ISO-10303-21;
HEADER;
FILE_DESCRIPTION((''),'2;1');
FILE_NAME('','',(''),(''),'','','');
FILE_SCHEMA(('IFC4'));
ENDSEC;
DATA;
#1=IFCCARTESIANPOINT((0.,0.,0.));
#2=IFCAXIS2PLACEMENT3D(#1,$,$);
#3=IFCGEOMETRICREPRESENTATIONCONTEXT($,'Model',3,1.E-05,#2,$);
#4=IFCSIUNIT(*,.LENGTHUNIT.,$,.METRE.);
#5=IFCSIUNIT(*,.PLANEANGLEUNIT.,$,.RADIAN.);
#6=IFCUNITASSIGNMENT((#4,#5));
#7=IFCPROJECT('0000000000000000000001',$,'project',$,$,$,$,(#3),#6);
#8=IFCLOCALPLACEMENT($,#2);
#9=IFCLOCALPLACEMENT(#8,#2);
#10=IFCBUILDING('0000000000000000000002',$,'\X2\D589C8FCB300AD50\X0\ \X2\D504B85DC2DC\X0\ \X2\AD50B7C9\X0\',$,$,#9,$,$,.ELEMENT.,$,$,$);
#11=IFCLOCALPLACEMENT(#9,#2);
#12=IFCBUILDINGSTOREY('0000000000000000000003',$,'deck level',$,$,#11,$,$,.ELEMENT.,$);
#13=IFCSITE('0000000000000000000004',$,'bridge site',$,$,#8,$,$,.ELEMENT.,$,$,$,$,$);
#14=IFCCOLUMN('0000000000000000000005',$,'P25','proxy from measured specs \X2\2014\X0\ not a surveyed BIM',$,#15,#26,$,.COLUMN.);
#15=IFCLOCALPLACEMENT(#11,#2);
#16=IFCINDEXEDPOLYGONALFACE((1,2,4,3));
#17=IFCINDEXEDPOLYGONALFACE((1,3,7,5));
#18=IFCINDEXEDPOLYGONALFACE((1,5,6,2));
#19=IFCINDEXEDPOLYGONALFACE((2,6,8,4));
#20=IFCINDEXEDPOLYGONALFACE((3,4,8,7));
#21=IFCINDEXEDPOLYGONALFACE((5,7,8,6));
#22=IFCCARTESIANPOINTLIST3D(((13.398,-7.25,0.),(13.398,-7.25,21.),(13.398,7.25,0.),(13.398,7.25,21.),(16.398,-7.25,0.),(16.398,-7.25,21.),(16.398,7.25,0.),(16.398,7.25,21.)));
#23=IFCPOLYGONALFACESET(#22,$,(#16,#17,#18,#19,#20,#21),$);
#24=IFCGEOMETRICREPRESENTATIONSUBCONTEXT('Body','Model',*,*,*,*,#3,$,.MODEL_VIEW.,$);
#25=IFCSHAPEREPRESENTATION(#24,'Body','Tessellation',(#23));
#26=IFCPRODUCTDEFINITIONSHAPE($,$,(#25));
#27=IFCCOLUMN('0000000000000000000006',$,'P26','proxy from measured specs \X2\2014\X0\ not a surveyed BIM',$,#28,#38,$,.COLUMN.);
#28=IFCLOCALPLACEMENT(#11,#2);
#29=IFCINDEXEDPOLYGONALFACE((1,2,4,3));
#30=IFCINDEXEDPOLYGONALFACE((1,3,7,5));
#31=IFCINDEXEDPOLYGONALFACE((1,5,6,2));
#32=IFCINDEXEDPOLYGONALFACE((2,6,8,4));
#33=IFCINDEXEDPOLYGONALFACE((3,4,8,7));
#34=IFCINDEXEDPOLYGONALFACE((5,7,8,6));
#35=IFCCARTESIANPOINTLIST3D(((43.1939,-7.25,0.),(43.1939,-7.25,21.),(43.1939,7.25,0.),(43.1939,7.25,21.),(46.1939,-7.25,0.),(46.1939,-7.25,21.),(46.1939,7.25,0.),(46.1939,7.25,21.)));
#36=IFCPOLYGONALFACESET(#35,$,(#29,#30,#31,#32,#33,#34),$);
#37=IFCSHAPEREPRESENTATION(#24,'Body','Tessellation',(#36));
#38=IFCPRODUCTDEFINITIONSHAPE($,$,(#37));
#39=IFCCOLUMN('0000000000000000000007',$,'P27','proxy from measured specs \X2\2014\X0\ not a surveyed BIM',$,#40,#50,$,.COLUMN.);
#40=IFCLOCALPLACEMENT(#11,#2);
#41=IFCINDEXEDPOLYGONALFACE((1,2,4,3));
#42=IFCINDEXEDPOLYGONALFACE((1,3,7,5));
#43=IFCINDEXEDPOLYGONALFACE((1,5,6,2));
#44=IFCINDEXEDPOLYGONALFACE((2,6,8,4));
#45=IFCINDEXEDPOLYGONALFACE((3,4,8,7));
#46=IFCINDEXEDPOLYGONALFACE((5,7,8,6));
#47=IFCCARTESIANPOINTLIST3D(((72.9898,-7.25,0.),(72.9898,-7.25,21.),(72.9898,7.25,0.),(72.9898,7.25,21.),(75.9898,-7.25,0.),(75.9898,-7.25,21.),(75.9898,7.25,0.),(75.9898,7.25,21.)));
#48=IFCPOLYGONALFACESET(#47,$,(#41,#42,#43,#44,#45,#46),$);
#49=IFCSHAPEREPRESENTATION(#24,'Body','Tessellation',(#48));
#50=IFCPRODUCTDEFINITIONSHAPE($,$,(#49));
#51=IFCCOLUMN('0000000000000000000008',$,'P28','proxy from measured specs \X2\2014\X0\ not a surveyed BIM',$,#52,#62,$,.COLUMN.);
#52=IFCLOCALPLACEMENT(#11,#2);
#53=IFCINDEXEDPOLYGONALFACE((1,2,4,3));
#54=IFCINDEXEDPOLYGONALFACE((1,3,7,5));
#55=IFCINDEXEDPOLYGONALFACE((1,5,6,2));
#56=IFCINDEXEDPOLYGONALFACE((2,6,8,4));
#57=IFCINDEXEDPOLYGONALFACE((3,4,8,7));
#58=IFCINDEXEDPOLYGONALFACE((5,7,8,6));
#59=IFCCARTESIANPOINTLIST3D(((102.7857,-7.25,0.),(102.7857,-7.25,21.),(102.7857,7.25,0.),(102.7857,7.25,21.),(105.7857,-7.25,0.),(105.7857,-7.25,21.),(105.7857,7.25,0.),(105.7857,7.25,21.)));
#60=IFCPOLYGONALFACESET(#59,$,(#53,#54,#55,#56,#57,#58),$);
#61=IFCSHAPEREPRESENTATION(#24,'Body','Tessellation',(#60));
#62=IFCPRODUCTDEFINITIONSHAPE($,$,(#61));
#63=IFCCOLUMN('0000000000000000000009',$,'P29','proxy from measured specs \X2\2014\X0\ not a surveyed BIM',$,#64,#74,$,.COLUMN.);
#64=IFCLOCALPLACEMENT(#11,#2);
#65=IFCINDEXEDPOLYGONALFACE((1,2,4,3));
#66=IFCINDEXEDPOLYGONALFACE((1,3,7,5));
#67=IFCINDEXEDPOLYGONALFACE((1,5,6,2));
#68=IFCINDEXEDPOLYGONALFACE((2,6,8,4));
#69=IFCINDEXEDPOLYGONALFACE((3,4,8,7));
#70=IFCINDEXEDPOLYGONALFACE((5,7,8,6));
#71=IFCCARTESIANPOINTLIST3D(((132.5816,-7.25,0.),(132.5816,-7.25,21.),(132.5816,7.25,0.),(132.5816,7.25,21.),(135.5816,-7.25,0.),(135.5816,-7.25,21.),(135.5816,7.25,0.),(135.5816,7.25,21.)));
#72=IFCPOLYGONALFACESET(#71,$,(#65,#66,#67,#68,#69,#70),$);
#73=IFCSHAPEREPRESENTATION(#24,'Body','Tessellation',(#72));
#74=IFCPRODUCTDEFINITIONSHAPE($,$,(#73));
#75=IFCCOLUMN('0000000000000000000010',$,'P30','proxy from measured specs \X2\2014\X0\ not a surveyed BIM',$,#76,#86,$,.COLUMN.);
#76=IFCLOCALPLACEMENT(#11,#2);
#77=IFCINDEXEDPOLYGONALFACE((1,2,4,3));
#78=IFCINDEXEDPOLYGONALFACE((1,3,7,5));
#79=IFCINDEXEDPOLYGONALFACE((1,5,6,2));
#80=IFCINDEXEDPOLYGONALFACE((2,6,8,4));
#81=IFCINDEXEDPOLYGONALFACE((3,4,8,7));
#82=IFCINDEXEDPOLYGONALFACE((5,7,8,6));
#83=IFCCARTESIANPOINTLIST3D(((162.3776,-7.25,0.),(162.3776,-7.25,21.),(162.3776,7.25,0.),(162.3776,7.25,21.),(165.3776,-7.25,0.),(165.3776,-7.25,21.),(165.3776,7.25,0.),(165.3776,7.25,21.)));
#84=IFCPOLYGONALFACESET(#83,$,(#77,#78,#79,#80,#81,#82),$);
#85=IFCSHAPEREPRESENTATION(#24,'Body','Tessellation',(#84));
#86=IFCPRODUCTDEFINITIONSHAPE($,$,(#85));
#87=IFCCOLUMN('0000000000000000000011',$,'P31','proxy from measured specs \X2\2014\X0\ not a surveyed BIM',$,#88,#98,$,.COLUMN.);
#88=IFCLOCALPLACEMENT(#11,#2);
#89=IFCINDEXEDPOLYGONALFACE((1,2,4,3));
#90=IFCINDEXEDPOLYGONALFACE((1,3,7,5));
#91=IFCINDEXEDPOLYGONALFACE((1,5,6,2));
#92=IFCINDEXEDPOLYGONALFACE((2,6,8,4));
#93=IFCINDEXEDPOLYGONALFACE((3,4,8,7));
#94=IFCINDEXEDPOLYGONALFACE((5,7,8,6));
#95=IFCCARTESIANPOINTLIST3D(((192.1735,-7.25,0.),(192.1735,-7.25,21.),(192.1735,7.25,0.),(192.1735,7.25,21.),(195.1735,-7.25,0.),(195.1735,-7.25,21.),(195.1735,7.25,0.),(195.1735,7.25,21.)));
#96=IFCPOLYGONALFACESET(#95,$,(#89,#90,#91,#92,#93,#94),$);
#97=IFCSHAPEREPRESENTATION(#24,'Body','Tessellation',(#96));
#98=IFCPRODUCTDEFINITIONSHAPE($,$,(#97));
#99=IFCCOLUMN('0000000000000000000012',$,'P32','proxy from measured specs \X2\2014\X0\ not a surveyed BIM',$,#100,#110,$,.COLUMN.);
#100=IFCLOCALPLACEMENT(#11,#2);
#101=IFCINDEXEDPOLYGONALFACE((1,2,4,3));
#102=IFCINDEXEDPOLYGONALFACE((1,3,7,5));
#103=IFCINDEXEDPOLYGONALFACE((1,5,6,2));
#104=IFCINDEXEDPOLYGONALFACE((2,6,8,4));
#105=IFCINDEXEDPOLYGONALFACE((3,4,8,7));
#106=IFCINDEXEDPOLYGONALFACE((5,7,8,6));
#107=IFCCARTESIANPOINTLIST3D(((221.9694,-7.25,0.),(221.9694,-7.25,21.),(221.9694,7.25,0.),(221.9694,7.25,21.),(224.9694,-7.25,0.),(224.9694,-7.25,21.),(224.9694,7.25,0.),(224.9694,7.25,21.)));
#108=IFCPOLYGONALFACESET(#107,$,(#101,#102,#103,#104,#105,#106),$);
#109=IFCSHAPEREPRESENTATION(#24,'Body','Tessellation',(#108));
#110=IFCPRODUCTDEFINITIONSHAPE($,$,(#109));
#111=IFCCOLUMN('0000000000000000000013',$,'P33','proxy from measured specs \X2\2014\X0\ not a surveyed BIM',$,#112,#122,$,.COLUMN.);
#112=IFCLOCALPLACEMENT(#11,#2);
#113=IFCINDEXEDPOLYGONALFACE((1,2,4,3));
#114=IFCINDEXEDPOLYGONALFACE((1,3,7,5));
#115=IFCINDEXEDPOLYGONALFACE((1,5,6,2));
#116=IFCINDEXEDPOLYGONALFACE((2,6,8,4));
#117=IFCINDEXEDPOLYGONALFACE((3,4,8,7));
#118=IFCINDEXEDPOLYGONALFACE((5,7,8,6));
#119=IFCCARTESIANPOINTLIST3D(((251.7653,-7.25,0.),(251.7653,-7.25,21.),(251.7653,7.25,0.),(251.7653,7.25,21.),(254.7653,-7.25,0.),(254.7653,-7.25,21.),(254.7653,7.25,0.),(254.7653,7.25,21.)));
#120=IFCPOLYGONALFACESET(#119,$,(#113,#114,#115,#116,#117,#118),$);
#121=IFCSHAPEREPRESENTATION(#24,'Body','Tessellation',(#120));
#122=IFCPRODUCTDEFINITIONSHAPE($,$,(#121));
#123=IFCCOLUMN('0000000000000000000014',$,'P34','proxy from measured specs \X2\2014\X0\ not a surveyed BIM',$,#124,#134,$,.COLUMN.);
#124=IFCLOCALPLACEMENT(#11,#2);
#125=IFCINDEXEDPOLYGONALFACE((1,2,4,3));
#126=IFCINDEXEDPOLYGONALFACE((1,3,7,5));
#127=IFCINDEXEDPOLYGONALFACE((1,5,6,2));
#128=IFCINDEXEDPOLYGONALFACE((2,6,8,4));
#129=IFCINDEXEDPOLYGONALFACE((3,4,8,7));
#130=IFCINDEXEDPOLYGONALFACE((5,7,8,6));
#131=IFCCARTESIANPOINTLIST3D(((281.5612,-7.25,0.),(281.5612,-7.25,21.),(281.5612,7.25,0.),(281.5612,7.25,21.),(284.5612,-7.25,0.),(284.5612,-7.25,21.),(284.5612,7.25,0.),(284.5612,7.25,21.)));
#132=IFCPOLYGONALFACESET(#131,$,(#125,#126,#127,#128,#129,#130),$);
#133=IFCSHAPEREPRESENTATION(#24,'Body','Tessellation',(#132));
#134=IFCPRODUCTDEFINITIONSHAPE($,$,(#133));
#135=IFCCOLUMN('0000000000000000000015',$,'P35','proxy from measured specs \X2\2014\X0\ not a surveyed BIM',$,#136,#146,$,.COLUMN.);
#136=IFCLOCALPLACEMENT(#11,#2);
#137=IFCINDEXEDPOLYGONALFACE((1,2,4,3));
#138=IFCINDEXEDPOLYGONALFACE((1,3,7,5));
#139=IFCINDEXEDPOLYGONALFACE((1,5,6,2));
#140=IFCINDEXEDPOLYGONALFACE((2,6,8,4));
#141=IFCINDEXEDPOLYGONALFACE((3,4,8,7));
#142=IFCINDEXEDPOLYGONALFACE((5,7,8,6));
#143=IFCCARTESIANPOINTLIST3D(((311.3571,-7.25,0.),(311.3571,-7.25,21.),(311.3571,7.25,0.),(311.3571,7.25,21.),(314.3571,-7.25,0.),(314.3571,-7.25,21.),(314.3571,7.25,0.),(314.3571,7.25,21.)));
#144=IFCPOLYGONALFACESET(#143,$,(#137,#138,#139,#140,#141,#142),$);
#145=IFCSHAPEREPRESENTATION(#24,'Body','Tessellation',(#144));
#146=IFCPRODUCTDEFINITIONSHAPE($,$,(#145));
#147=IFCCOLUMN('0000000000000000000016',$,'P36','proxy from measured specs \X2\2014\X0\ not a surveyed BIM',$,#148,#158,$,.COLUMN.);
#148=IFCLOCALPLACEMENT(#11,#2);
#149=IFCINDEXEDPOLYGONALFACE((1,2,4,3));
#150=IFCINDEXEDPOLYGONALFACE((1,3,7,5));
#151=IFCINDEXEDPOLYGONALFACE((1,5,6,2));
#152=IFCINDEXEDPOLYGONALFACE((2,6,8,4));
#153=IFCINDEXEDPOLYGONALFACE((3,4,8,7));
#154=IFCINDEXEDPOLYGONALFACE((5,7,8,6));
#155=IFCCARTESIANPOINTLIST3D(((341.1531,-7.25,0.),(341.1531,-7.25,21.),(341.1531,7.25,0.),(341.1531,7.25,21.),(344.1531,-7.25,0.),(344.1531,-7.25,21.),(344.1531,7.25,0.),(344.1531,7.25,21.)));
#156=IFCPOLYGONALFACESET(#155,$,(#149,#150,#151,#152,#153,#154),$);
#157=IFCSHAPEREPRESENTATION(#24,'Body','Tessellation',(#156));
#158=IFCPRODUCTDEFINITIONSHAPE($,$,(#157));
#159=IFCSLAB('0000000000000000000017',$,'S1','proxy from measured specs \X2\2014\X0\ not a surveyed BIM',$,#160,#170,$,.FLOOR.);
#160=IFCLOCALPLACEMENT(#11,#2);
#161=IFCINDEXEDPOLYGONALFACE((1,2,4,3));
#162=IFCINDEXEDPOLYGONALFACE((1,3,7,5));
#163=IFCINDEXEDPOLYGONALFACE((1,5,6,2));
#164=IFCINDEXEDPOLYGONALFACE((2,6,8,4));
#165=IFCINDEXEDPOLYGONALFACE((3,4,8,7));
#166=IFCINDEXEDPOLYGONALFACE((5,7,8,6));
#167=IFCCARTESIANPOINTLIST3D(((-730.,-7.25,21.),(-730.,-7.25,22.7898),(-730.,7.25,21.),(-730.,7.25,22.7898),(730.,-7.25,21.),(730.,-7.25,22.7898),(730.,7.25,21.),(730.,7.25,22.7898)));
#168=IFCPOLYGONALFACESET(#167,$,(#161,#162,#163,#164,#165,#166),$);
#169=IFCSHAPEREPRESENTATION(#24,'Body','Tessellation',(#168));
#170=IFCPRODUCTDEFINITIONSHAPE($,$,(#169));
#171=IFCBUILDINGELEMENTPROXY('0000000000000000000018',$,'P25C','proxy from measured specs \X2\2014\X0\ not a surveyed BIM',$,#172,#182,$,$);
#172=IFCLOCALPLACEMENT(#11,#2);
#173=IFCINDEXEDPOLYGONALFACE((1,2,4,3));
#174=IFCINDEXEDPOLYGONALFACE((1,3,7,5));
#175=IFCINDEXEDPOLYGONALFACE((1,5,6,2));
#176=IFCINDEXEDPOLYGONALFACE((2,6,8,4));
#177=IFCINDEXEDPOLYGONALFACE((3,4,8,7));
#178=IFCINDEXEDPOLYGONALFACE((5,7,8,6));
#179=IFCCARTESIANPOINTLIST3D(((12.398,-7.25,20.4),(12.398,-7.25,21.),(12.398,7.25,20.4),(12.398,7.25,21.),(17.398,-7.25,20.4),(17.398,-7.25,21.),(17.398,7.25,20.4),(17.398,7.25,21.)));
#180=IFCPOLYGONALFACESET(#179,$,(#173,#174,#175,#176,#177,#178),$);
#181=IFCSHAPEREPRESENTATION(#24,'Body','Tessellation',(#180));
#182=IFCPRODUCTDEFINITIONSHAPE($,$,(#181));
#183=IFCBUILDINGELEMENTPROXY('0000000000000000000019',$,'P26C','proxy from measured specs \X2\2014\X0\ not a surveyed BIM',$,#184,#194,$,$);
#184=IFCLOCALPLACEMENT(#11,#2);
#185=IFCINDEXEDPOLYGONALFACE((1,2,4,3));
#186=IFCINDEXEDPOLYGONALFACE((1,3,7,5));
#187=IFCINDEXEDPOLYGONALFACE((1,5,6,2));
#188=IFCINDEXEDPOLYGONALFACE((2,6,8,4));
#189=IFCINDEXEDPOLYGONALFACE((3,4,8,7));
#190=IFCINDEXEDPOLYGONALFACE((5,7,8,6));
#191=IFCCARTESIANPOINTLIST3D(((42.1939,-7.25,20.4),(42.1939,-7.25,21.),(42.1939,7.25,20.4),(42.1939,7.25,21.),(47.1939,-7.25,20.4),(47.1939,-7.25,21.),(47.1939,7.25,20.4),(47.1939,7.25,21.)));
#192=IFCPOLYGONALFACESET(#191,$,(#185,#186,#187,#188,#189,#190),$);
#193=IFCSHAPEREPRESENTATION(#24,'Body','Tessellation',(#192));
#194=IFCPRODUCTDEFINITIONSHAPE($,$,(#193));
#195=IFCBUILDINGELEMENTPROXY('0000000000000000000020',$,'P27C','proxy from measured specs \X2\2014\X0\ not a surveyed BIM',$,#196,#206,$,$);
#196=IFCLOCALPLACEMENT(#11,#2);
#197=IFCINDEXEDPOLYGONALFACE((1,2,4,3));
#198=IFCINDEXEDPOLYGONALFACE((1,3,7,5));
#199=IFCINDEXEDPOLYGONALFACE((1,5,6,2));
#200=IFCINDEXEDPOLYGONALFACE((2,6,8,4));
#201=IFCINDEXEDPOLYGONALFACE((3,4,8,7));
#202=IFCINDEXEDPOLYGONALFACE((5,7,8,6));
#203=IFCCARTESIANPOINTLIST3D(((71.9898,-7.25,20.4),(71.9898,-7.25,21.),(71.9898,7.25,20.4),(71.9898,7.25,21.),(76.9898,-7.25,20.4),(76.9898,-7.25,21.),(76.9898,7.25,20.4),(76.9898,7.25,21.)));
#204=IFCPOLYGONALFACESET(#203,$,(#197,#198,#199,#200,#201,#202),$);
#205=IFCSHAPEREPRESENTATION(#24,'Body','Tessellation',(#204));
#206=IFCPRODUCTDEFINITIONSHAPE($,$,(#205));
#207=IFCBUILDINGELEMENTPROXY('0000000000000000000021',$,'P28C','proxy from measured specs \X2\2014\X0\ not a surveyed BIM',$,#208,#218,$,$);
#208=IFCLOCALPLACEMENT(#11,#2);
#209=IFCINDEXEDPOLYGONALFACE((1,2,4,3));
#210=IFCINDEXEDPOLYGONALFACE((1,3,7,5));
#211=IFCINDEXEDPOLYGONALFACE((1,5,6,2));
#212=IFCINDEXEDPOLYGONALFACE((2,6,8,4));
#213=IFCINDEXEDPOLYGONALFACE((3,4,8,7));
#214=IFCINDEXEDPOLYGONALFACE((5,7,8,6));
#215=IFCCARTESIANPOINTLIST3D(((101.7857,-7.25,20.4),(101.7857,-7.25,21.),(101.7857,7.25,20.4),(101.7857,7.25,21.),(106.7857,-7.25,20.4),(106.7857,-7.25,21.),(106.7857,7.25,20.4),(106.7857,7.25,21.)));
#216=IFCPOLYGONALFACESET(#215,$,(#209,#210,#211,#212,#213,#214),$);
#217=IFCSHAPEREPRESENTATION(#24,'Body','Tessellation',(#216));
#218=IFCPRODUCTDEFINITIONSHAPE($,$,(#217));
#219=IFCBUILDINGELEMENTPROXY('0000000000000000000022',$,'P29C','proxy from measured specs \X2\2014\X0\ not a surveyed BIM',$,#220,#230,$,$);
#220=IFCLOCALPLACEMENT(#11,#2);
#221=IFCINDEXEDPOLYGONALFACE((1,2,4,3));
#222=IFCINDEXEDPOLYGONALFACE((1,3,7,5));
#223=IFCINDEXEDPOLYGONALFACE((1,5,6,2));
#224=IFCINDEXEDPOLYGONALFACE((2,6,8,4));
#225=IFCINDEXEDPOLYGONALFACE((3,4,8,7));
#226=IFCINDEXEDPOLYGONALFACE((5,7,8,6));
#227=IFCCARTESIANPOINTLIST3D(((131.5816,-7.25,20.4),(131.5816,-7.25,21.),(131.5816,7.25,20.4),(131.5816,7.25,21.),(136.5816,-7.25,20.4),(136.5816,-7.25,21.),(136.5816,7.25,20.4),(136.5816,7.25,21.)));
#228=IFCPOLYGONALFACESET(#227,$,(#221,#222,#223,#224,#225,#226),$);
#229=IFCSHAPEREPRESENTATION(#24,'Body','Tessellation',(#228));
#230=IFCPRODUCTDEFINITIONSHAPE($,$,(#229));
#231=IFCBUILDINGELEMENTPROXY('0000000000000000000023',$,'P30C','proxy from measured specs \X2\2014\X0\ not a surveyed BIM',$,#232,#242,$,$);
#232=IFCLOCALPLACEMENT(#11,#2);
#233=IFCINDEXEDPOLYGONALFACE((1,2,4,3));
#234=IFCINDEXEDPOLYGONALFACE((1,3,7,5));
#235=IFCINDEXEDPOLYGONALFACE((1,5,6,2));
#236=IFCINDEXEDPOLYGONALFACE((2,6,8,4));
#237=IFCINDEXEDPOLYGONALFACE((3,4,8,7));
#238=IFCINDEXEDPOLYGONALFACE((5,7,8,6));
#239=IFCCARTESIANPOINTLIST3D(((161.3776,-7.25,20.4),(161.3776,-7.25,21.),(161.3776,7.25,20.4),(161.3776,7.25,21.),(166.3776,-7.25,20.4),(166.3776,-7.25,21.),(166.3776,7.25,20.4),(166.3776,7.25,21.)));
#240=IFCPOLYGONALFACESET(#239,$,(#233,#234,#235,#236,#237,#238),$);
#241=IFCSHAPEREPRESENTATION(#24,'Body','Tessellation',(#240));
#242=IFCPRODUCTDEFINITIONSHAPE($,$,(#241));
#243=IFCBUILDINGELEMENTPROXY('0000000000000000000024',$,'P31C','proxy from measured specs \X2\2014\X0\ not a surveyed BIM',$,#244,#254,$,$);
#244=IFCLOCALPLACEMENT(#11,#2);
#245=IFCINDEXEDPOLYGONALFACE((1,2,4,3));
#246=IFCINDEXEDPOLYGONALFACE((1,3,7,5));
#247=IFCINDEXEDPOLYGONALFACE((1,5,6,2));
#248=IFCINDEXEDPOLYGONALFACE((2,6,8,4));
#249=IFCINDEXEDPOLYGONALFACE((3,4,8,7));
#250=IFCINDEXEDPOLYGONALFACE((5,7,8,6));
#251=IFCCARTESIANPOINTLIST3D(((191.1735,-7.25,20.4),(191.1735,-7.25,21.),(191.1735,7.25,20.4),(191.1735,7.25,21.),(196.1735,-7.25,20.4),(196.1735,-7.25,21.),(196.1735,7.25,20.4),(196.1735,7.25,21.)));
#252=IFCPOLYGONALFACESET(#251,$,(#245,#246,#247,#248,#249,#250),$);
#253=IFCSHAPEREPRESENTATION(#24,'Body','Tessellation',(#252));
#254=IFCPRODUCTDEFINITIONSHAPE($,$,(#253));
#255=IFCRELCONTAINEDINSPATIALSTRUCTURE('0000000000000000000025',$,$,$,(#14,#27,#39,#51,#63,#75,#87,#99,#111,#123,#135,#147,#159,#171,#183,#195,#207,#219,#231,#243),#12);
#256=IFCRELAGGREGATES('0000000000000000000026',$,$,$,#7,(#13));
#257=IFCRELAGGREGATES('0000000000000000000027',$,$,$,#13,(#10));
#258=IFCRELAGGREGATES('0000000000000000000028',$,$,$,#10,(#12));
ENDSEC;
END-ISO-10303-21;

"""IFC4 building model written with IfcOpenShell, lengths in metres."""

from ifc_helpers import new_model, si_unit, frame, origin, origin_2d, place, context, subcontext, project, spatial, rectangle, extrude, element, save


model = new_model("IFC4")

# Units and contexts
model_context = context("Model", 3, precision=1e-05, world=origin())
body_context = subcontext(model_context, "Body", "Model", "MODEL_VIEW")
ifc_project = project(units=[si_unit("LENGTHUNIT", "METRE"), si_unit("PLANEANGLEUNIT", "RADIAN")], contexts=[model_context])

# Site, building, storey
site_placement = place(None, origin())
site = spatial("IfcSite", under=ifc_project, at=site_placement, Name="bridge site", CompositionType="ELEMENT")
building_placement = place(site_placement, origin())
building = spatial("IfcBuilding", under=site, at=building_placement, Name="행주대교 프록시 교량", CompositionType="ELEMENT")
storey_placement = place(building_placement, origin())
storey = spatial("IfcBuildingStorey", under=building, at=storey_placement, Name="deck level", CompositionType="ELEMENT")

# Columns
for number, where, name in (
    (1, (14.898, 0.0, 0.0), "P25"),
    (2, (44.6939, 0.0, 0.0), "P26"),
    (3, (74.4898, 0.0, 0.0), "P27"),
    (4, (104.2857, 0.0, 0.0), "P28"),
    (5, (134.0816, 0.0, 0.0), "P29"),
    (6, (163.8776, 0.0, 0.0), "P30"),
    (7, (193.6735, 0.0, 0.0), "P31"),
    (8, (223.4694, 0.0, 0.0), "P32"),
    (9, (253.2653, 0.0, 0.0), "P33"),
    (10, (283.0612, 0.0, 0.0), "P34"),
    (11, (312.8571, 0.0, 0.0), "P35"),
    (12, (342.6531, 0.0, 0.0), "P36"),
):
    element("IfcColumn", number, at=place(storey_placement, frame(where)), inside=storey, Name=name, Description="proxy from measured specs — not a surveyed BIM", PredefinedType="COLUMN", context=body_context, shape_type="SweptSolid", body=[
        extrude(rectangle(XDim=3.0, YDim=14.5, at=origin_2d()), origin(), (0.0, 0.0, 1.0), 21.0),
    ])

# Slab
slab_placement = place(storey_placement, frame((0.0, 0.0, 21.0)))
element("IfcSlab", 13, at=slab_placement, inside=storey, Name="S1", Description="proxy from measured specs — not a surveyed BIM", PredefinedType="FLOOR", context=body_context, shape_type="SweptSolid", body=[
    extrude(rectangle(XDim=1460.0, YDim=14.5, at=origin_2d()), origin(), (0.0, 0.0, 1.0), 1.7898),
])

# Building element proxies
for number, where, name in (
    (14, (14.898, 0.0, 20.4), "P25C"),
    (15, (44.6939, 0.0, 20.4), "P26C"),
    (16, (74.4898, 0.0, 20.4), "P27C"),
    (17, (104.2857, 0.0, 20.4), "P28C"),
    (18, (134.0816, 0.0, 20.4), "P29C"),
    (19, (163.8776, 0.0, 20.4), "P30C"),
    (20, (193.6735, 0.0, 20.4), "P31C"),
):
    element("IfcBuildingElementProxy", number, at=place(storey_placement, frame(where)), inside=storey, Name=name, Description="proxy from measured specs — not a surveyed BIM", context=body_context, shape_type="SweptSolid", body=[
        extrude(rectangle(XDim=5.0, YDim=14.5, at=origin_2d()), origin(), (0.0, 0.0, 1.0), 0.6),
    ])

save(model, "model.ifc")
